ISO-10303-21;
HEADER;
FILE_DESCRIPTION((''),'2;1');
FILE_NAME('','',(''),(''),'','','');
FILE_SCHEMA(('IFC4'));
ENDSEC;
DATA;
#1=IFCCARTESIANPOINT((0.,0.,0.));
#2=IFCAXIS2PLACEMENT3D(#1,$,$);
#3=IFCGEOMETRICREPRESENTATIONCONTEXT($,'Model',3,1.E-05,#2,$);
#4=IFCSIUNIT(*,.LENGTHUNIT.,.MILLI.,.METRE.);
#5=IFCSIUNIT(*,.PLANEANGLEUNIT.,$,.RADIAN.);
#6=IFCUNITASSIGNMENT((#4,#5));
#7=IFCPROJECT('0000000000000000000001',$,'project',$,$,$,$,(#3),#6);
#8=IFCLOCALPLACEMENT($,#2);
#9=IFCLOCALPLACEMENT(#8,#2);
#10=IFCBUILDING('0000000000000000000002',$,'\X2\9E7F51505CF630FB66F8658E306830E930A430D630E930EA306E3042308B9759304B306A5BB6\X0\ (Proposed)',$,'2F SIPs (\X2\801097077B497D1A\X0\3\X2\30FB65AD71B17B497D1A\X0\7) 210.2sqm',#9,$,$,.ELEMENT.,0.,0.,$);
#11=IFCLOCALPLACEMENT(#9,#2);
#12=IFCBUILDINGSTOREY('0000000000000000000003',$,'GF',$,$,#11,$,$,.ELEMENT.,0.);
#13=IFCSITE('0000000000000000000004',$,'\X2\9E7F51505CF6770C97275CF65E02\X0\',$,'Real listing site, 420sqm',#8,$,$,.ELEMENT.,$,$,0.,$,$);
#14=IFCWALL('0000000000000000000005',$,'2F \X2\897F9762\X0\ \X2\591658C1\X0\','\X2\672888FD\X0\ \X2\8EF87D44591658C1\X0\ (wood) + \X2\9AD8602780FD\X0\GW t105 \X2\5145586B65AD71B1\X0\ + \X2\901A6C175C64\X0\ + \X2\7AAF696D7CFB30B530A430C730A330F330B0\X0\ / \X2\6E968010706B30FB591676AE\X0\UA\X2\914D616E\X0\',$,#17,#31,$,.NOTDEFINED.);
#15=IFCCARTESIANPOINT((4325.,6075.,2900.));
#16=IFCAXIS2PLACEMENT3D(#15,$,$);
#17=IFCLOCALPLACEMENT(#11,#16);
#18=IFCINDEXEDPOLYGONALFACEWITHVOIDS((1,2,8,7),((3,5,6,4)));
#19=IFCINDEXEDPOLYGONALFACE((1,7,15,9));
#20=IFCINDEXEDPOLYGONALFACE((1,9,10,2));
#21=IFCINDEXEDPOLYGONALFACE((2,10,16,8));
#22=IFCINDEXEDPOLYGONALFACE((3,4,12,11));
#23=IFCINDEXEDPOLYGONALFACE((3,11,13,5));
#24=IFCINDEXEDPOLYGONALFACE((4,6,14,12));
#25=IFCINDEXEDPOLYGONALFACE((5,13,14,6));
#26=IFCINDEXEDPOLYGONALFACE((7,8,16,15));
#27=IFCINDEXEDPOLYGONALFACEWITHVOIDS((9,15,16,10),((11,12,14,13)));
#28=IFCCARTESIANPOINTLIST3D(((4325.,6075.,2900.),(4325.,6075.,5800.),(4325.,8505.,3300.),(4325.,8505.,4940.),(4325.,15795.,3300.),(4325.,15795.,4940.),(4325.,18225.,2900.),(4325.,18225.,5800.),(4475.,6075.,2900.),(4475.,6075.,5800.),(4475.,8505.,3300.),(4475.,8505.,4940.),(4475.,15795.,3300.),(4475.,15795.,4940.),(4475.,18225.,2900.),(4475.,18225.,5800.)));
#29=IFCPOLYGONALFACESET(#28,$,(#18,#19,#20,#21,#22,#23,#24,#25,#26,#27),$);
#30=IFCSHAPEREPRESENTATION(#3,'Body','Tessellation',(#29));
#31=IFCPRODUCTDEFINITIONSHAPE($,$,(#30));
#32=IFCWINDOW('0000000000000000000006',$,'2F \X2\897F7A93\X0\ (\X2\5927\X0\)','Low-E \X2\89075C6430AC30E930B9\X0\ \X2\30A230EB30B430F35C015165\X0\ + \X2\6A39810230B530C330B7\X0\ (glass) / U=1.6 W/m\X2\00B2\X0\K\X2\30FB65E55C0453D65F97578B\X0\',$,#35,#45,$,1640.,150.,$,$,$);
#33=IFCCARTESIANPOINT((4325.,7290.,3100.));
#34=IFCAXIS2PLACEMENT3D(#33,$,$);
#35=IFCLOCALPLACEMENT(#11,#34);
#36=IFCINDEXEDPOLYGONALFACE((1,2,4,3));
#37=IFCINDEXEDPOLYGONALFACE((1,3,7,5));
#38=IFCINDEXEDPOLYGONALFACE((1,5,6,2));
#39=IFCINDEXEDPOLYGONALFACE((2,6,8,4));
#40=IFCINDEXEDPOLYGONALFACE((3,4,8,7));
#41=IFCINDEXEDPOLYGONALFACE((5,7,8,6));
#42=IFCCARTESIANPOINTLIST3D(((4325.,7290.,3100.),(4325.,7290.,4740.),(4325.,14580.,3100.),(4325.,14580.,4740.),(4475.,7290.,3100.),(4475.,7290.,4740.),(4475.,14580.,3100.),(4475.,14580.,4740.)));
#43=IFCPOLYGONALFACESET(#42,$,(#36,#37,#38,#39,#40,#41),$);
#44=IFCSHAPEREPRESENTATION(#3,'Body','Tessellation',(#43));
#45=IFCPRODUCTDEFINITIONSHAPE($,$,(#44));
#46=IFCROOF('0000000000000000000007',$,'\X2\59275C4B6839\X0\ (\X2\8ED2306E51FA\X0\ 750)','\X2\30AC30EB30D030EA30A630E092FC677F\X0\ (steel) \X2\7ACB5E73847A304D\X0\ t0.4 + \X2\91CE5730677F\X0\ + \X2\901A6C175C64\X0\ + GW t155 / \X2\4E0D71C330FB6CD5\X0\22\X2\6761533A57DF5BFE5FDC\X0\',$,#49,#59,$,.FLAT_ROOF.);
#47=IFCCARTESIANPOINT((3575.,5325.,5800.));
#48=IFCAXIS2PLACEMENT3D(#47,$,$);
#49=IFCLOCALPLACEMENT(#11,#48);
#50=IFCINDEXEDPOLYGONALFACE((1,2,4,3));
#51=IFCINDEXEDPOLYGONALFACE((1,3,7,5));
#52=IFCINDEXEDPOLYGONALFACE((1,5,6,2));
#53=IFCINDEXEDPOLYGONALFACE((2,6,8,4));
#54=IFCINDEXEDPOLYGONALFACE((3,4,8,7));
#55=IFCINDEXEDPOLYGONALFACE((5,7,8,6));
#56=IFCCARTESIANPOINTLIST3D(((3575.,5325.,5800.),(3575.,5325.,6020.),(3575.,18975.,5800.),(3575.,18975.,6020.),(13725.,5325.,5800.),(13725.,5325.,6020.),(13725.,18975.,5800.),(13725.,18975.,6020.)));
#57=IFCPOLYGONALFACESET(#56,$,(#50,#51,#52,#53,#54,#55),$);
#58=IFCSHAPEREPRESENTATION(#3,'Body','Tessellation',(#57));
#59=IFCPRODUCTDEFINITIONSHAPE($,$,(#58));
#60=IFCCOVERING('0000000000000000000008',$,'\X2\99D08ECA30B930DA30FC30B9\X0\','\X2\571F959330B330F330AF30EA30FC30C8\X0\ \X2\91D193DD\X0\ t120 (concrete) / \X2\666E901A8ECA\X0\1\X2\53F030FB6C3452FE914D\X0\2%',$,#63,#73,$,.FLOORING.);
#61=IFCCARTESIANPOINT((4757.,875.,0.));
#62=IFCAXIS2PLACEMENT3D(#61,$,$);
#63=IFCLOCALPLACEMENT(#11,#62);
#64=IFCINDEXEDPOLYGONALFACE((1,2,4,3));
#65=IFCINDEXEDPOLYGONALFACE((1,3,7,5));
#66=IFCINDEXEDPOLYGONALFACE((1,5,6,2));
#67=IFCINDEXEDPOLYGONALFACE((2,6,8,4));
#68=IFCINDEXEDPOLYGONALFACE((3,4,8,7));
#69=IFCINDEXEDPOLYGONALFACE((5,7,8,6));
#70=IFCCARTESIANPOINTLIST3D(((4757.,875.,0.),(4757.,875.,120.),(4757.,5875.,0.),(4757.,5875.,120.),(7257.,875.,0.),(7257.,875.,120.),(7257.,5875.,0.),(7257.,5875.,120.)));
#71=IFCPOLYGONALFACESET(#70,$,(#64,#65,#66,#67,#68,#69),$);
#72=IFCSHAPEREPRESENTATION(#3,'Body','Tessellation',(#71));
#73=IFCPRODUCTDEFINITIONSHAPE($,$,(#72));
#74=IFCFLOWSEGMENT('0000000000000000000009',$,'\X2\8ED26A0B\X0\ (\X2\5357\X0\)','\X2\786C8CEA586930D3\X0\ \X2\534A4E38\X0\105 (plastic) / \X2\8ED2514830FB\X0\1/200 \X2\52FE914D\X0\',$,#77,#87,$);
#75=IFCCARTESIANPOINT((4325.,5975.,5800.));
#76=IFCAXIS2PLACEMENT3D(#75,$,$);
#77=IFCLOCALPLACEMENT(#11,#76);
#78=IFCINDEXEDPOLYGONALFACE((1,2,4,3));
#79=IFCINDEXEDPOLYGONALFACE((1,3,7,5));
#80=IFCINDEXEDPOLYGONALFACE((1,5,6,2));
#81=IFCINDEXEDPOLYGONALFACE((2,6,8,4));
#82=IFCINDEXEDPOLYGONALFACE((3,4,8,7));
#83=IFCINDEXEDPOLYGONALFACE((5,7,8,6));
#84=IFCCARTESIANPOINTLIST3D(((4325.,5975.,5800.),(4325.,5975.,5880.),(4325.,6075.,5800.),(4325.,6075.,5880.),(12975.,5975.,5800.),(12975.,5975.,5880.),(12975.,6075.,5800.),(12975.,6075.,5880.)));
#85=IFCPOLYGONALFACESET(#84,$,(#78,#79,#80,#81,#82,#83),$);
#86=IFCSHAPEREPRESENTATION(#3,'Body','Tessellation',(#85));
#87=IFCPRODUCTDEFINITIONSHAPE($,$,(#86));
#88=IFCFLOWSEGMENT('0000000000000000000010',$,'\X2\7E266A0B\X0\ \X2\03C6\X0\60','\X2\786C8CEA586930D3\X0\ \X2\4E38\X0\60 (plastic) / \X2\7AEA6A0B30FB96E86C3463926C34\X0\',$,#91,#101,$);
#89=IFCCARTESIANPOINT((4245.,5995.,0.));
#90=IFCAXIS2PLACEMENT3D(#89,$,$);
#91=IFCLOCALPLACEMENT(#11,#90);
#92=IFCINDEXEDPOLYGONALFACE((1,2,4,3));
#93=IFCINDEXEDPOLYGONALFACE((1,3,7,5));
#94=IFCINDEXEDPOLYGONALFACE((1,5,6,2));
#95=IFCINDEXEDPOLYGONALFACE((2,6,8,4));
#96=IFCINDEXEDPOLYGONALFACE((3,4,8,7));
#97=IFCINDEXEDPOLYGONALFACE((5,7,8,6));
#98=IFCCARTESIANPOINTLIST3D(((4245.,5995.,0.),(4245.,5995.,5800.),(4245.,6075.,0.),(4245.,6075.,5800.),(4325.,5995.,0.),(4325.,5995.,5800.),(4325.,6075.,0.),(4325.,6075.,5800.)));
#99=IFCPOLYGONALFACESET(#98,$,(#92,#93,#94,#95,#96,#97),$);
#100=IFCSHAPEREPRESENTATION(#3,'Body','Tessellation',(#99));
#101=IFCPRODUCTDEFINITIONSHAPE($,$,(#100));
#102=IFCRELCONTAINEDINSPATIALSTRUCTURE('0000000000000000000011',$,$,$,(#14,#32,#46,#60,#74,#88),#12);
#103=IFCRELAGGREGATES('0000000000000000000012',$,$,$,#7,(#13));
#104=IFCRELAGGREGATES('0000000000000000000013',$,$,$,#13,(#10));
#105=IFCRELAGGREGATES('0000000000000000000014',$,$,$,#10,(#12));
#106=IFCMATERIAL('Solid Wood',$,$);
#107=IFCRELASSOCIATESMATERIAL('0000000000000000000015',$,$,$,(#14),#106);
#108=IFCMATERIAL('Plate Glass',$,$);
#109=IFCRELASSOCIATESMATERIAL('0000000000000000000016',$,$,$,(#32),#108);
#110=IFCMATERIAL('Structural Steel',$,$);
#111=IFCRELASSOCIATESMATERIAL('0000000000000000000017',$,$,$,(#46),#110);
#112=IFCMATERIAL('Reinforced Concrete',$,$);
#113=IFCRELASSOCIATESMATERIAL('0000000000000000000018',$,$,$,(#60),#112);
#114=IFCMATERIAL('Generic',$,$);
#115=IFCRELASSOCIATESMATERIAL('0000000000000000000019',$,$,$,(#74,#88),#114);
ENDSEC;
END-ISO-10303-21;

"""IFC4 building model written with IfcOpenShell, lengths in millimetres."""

from ifc_helpers import new_model, si_unit, frame, frame_2d, origin, place, context, project, spatial, rectangle, extrude, material, element, fill, save


model = new_model("IFC4")

# Units and contexts
model_context = context("Model", 3, precision=1e-05, world=origin())
ifc_project = project(units=[si_unit("LENGTHUNIT", "METRE", prefix="MILLI"), si_unit("PLANEANGLEUNIT", "RADIAN")], contexts=[model_context])

# Site, building, storey
site_placement = place(None, origin())
site = spatial("IfcSite", under=ifc_project, at=site_placement, Name="鹿児島県霧島市", ObjectType="Real listing site, 420sqm", CompositionType="ELEMENT", RefElevation=0.0)
building_placement = place(site_placement, origin())
building = spatial("IfcBuilding", under=site, at=building_placement, Name="鹿児島・書斎とライブラリのある静かな家 (Proposed)", ObjectType="2F SIPs (耐震等級3・断熱等級7) 210.2sqm", CompositionType="ELEMENT", ElevationOfRefHeight=0.0, ElevationOfTerrain=0.0)
storey_placement = place(building_placement, origin())
storey = spatial("IfcBuildingStorey", under=building, at=storey_placement, Name="GF", CompositionType="ELEMENT", Elevation=0.0)

# Shared definitions
ifc_material_1 = material(Name="Solid Wood")

# Shared definitions
ifc_material_2 = material(Name="Reinforced Concrete")

# Shared definitions
ifc_material_3 = material(Name="Plate Glass")

# Wall, opening, window
wall_1_placement = place(storey_placement, frame((4325.0, 6075.0, 2900.0)))
wall_1 = element("IfcWall", 1, at=wall_1_placement, inside=storey, material=ifc_material_1, Name="2F 西面 外壁", Description="木製 軸組外壁 (wood) + 高性能GW t105 充填断熱 + 通気層 + 窯業系サイディング / 準耐火・外皮UA配慮", PredefinedType="NOTDEFINED", context=model_context, shape_type="SweptSolid", body=[
    extrude(rectangle(XDim=150.0, YDim=12150.0, at=frame_2d((75.0, 6075.0))), frame((4325.0, 6075.0, 2900.0)), (0.0, 0.0, 1.0), 2900.0),
])
opening_1_placement = place(storey_placement, frame((4325.0, 7290.0, 3100.0)))
opening_1 = element("IfcOpeningElement", 2, at=opening_1_placement, cuts=wall_1, PredefinedType="NOTDEFINED", context=model_context, shape_type="SweptSolid", body=[
    extrude(rectangle(XDim=150.0, YDim=7290.0, at=frame_2d((75.0, 3645.0))), frame((4325.0, 7290.0, 3100.0)), (0.0, 0.0, 1.0), 1640.0),
])
window_1_placement = place(storey_placement, frame((4325.0, 7290.0, 3100.0)))
window_1 = element("IfcWindow", 3, at=window_1_placement, inside=storey, material=ifc_material_3, Name="2F 西窓 (大)", Description="Low-E 複層ガラス アルゴン封入 + 樹脂サッシ (glass) / U=1.6 W/m²K・日射取得型", OverallHeight=1640.0, OverallWidth=150.0, context=model_context, shape_type="SweptSolid", body=[
    extrude(rectangle(XDim=150.0, YDim=7290.0, at=frame_2d((75.0, 3645.0))), frame((4325.0, 7290.0, 3100.0)), (0.0, 0.0, 1.0), 1640.0),
])
fill(opening_1, window_1)

# Roof
ifc_material_4 = material(Name="Structural Steel")
roof_placement = place(storey_placement, frame((3575.0, 5325.0, 5800.0)))
element("IfcRoof", 4, at=roof_placement, inside=storey, material=ifc_material_4, Name="大屋根 (軒の出 750)", Description="ガルバリウム鋼板 (steel) 立平葺き t0.4 + 野地板 + 通気層 + GW t155 / 不燃・法22条区域対応", PredefinedType="FLAT_ROOF", context=model_context, shape_type="SweptSolid", body=[
    extrude(rectangle(XDim=10150.0, YDim=13650.0, at=frame_2d((5075.0, 6825.0))), frame((3575.0, 5325.0, 5800.0)), (0.0, 0.0, 1.0), 220.0),
])

# Covering
covering_placement = place(storey_placement, frame((4757.0, 875.0, 0.0)))
element("IfcCovering", 5, at=covering_placement, inside=storey, material=ifc_material_2, Name="駐車スペース", Description="土間コンクリート 金鏝 t120 (concrete) / 普通車1台・水勾配2%", PredefinedType="FLOORING", context=model_context, shape_type="SweptSolid", body=[
    extrude(rectangle(XDim=2500.0, YDim=5000.0, at=frame_2d((1250.0, 2500.0))), frame((4757.0, 875.0, 0.0)), (0.0, 0.0, 1.0), 120.0),
])

# Flow segments
ifc_material_5 = material(Name="Generic")
flow_segment_1_placement = place(storey_placement, frame((4325.0, 5975.0, 5800.0)))
element("IfcFlowSegment", 6, at=flow_segment_1_placement, inside=storey, material=ifc_material_5, Name="軒樋 (南)", Description="硬質塩ビ 半丸105 (plastic) / 軒先・1/200 勾配", context=model_context, shape_type="SweptSolid", body=[
    extrude(rectangle(XDim=8650.0, YDim=100.0, at=frame_2d((4325.0, 50.0))), frame((4325.0, 5975.0, 5800.0)), (0.0, 0.0, 1.0), 80.0),
])
flow_segment_2_placement = place(storey_placement, frame((4245.0, 5995.0, 0.0)))
element("IfcFlowSegment", 7, at=flow_segment_2_placement, inside=storey, material=ifc_material_5, Name="縦樋 φ60", Description="硬質塩ビ 丸60 (plastic) / 竪樋・雨水排水", context=model_context, shape_type="SweptSolid", body=[
    extrude(rectangle(XDim=80.0, YDim=80.0, at=frame_2d((40.0, 40.0))), frame((4245.0, 5995.0, 0.0)), (0.0, 0.0, 1.0), 5800.0),
])

save(model, "model.ifc")
